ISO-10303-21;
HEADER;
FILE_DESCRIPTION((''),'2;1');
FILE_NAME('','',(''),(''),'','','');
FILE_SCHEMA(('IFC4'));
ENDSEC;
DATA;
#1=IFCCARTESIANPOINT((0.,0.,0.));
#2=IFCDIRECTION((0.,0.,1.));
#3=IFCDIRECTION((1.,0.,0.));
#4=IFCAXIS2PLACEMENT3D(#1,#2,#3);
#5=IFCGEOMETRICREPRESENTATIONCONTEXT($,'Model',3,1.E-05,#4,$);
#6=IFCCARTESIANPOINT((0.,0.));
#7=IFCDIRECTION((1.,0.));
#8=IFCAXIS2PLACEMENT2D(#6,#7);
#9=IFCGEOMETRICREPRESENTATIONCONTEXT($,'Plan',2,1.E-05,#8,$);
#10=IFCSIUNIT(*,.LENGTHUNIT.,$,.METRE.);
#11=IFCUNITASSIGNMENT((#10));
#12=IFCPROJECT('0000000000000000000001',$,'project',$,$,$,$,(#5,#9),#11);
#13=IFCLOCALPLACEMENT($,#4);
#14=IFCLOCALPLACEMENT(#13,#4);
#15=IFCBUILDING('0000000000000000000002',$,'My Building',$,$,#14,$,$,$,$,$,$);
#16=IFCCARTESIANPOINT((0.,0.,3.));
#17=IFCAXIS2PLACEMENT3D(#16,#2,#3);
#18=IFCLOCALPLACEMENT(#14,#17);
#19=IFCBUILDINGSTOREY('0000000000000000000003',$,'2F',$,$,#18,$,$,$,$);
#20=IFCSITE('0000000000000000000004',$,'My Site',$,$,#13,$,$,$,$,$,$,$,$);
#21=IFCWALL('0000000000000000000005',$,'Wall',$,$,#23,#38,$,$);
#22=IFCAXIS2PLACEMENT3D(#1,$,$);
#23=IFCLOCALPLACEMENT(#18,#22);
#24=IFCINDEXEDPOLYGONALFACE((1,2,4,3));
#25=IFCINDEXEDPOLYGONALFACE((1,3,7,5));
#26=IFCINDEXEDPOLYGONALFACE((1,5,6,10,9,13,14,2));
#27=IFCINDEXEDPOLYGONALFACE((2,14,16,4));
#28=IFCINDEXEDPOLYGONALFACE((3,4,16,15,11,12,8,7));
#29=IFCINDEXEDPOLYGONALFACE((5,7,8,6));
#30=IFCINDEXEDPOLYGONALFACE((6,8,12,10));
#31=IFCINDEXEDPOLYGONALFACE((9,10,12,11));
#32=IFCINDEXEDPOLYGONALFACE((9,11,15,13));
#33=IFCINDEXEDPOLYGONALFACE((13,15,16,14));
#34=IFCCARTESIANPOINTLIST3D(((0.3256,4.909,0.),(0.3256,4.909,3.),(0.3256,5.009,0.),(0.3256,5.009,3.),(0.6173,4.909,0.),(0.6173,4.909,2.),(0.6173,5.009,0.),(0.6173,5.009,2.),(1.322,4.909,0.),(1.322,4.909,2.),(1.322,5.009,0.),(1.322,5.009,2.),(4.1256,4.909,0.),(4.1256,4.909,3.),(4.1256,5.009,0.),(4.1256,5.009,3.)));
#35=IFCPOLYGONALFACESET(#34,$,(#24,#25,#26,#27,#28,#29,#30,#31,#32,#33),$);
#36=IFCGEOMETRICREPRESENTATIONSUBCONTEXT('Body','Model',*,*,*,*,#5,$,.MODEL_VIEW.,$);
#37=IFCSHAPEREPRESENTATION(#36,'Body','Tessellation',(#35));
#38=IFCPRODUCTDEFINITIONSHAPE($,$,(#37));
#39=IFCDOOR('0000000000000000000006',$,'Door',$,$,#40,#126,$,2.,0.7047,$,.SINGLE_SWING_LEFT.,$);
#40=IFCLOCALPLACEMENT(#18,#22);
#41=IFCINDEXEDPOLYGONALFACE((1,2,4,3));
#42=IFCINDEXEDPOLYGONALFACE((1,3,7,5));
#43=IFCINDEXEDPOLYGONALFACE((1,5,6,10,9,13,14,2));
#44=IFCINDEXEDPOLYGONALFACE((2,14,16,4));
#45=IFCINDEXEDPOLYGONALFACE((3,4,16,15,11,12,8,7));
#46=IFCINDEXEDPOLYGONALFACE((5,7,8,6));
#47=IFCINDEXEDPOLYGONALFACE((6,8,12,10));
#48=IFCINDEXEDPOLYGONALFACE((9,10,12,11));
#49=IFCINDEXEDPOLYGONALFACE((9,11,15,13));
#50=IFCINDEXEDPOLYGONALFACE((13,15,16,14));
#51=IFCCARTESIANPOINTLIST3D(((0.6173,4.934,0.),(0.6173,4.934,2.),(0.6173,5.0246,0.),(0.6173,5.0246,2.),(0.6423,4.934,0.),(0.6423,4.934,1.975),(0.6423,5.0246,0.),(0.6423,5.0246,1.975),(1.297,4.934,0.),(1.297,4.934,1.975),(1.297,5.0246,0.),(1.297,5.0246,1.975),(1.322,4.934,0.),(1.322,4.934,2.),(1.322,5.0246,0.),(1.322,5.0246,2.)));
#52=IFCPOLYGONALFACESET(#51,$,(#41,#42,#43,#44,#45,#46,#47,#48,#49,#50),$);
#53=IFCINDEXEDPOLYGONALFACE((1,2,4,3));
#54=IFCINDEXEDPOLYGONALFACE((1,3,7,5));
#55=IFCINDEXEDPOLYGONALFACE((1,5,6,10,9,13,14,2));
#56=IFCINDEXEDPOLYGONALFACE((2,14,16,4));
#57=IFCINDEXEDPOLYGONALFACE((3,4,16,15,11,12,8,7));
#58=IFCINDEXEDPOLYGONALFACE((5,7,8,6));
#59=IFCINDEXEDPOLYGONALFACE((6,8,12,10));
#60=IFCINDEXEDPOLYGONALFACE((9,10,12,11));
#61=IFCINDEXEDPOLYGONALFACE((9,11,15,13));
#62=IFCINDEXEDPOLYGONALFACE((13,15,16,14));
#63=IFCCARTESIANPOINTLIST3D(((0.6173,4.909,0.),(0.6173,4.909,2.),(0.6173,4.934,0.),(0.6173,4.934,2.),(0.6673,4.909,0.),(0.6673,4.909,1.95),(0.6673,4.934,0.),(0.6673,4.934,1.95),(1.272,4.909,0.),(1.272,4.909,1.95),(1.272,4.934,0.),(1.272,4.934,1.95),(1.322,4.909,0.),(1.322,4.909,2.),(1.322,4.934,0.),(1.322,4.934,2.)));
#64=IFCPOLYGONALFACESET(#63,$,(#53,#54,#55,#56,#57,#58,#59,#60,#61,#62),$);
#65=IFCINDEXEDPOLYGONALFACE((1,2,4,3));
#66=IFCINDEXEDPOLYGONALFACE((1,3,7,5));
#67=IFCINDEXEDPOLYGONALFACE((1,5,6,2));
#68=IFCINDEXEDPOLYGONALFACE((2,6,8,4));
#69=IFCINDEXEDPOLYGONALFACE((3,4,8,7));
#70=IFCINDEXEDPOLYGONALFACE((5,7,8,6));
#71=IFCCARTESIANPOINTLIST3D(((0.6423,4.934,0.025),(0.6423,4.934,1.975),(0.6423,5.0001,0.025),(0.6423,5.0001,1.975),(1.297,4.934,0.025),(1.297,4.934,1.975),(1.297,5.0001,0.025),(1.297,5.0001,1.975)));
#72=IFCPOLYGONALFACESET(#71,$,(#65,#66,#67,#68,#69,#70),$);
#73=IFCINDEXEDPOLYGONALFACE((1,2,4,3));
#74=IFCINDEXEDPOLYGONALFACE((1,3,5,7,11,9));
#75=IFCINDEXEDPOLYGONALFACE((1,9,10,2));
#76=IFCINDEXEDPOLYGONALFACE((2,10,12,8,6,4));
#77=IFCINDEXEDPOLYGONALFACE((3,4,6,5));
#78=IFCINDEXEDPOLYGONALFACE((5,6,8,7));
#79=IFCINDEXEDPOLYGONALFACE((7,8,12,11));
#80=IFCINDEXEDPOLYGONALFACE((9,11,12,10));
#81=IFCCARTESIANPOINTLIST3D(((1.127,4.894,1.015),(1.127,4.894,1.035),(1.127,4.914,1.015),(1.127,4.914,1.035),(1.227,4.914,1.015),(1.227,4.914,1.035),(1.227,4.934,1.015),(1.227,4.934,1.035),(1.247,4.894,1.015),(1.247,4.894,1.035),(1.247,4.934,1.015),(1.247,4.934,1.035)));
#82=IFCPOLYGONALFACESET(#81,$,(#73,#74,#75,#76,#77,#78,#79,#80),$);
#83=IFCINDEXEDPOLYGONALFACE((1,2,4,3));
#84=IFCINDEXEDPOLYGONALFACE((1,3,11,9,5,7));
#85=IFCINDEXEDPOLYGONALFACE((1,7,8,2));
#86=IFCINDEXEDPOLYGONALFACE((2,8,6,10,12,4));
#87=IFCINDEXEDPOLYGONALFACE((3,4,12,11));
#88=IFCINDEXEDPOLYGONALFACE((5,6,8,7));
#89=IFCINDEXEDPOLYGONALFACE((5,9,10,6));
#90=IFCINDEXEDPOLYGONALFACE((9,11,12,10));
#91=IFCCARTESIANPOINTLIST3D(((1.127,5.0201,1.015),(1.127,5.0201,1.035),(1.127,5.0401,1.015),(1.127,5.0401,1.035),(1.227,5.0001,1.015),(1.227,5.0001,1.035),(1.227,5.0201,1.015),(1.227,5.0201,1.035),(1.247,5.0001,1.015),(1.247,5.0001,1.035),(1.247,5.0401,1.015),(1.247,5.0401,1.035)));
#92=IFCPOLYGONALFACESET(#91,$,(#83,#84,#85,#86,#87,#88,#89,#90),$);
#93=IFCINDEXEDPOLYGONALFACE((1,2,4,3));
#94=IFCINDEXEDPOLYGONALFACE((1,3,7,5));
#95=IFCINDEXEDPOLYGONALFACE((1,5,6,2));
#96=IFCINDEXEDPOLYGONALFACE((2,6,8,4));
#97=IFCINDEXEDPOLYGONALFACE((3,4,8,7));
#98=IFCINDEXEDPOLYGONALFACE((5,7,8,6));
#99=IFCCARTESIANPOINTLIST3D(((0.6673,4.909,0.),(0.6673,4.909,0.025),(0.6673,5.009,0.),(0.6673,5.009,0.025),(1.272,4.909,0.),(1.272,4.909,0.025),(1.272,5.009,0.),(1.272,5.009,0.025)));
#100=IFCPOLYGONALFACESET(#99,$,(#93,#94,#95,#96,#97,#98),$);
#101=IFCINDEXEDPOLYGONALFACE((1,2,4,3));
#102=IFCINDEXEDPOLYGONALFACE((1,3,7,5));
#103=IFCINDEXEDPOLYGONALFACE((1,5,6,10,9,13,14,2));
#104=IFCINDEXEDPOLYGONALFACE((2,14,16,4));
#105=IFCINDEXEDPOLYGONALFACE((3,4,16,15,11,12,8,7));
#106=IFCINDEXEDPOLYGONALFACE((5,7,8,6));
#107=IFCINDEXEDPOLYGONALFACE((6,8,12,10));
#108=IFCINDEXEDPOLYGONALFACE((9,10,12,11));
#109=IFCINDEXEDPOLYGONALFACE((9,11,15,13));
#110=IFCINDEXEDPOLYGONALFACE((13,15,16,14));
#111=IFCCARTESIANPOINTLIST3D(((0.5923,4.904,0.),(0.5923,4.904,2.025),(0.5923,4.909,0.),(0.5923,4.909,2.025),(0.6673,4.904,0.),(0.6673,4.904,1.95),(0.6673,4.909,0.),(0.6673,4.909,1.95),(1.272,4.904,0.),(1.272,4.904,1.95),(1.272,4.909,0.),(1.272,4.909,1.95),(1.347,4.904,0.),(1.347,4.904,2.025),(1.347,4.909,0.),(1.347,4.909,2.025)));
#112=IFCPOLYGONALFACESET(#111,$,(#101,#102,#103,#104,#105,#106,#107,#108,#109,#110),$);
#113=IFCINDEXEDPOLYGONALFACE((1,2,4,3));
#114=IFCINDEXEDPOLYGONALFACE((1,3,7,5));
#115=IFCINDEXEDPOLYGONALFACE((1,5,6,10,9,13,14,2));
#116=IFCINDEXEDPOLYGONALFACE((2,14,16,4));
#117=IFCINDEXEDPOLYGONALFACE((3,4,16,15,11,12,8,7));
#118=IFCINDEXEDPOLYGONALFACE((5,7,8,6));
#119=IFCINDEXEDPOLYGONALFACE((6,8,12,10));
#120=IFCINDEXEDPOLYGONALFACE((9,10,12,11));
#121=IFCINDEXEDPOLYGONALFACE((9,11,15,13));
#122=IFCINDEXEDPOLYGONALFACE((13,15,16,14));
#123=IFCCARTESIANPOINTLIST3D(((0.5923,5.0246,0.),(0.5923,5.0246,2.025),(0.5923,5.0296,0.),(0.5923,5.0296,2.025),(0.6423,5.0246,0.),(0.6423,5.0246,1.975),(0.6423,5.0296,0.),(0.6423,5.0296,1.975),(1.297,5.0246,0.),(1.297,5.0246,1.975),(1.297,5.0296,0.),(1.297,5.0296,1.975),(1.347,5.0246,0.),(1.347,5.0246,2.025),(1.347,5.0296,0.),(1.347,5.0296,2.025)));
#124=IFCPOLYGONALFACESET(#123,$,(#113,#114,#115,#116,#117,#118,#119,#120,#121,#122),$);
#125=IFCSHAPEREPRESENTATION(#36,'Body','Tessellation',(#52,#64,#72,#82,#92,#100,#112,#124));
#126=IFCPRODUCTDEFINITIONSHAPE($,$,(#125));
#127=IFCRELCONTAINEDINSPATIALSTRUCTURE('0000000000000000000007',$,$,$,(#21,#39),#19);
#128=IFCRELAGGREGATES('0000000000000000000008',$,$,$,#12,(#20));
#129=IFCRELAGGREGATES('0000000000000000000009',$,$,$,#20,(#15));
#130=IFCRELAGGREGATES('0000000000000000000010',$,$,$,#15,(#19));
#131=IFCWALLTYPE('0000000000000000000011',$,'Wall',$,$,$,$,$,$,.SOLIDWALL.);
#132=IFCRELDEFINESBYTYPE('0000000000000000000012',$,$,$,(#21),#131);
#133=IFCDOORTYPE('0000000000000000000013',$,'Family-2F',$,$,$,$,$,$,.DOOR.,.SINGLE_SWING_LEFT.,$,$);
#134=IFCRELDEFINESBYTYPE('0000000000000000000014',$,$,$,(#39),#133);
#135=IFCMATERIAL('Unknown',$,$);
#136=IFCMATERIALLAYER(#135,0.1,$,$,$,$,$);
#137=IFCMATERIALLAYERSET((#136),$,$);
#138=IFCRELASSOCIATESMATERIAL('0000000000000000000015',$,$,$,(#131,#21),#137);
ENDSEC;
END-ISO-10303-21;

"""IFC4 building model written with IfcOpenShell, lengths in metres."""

from ifc_helpers import new_model, entity, si_unit, frame, origin_with_axes, origin_2d_with_axis, place, context, subcontext, project, spatial, line, indexed_curve, outline, extrude, shape, source, transform, mapped, material, layer, layer_set, layer_usage, type_object, type_shapes, element, fill, save


model = new_model("IFC4")

# Units and contexts
model_context = context("Model", 3, precision=1e-05, world=origin_with_axes())
plan_context = context("Plan", 2, precision=1e-05, world=origin_2d_with_axis())
body_context_1 = subcontext(model_context, "Body", "Model", "MODEL_VIEW")
body_context_2 = subcontext(plan_context, "Body", "Plan", "PLAN_VIEW")
ifc_project = project(units=[si_unit("LENGTHUNIT", "METRE")], contexts=[model_context, plan_context])

# Site, building, storey
site_placement = place(None, origin_with_axes())
site = spatial("IfcSite", under=ifc_project, at=site_placement, Name="My Site")
building_placement = place(site_placement, origin_with_axes())
building = spatial("IfcBuilding", under=site, at=building_placement, Name="My Building")
storey_placement = place(building_placement, frame((0.0, 0.0, 3.0), z_axis=(0.0, 0.0, 1.0), x_axis=(1.0, 0.0, 0.0)))
storey = spatial("IfcBuildingStorey", under=building, at=storey_placement, Name="2F")

# Shared definitions
ifc_material = material(Name="Unknown")

# Shared definitions
ifc_layer_1 = layer(ifc_material, 0.1)
ifc_layer_set_1 = layer_set([ifc_layer_1])
wall_type = type_object("IfcWallType", Name="Wall", PredefinedType="SOLIDWALL", material=ifc_layer_set_1)

# Wall, opening, door
ifc_layer_usage_1 = layer_usage(ifc_layer_set_1, "AXIS2", "POSITIVE", 0.0)
wall_1_placement = place(storey_placement, frame((4.1256, 5.009, 0.0), z_axis=(0.0, 0.0, 1.0), x_axis=(-1.0, 0.0, 0.0)))
wall_1 = element("IfcWall", 1, at=wall_1_placement, inside=storey, type_object=wall_type, material=ifc_layer_usage_1, Name="Wall", context=body_context_1, shape_type="SweptSolid", body=[
    extrude(outline(indexed_curve([(0.0, 0.0), (0.0, 0.1), (3.8, 0.1), (3.8, 0.0)], segments=[line(1, 2, 3, 4, 1)])), origin_with_axes(), (0.0, 0.0, 1.0), 3.0),
])
shared_shape_1 = source(origin_with_axes(), body_context_1, "Body", "SweptSolid", [
    extrude(outline(indexed_curve([(0.0, 0.0), (0.7047, 0.0), (0.7047, 2.0), (0.0, 2.0)], segments=[line(1, 2, 3, 4, 1)])), frame((0.0, -0.6, 0.0), z_axis=(0.0, -1.0, 0.0), x_axis=(1.0, 0.0, 0.0)), (0.0, 0.0, -1.0), 1.2),
])
opening_1_placement = place(wall_1_placement, frame((3.5083, 0.1, 0.0), z_axis=(0.0, 0.0, 1.0), x_axis=(-1.0, 0.0, 0.0)))
opening_1 = element("IfcOpeningElement", 2, at=opening_1_placement, cuts=wall_1, PredefinedType="OPENING", context=body_context_1, shape_type="MappedRepresentation", body=[
    mapped(shared_shape_1, transform((0.0, 0.0, 0.0), x_axis=(1.0, 0.0, 0.0), y_axis=(0.0, 1.0, 0.0), z_axis=(0.0, 0.0, 1.0), scale=1.0)),
])
door_type_1 = type_object("IfcDoorType", Name="Family-2F", OperationType="SINGLE_SWING_LEFT", PredefinedType="DOOR")
shared_shape_2 = source(origin_with_axes(), body_context_1, "Body", "SweptSolid", [
    extrude(outline(indexed_curve([(0.0, 0.0), (0.0, 2.0), (0.7047, 2.0), (0.7047, 0.0), (0.6797, 0.0), (0.6797, 1.975), (0.025, 1.975), (0.025, 0.0)], segments=[line(1, 2, 3, 4, 5, 6, 7, 8, 1)])), frame((0.0, 0.025, 0.0), z_axis=(0.0, -1.0, 0.0), x_axis=(1.0, 0.0, 0.0)), (0.0, 0.0, -1.0), 0.0906),
    extrude(outline(indexed_curve([(0.0, 0.0), (0.0, 2.0), (0.7047, 2.0), (0.7047, 0.0), (0.6547, 0.0), (0.6547, 1.95), (0.05, 1.95), (0.05, 0.0)], segments=[line(1, 2, 3, 4, 5, 6, 7, 8, 1)])), frame((0.0, 0.0, 0.0), z_axis=(0.0, -1.0, 0.0), x_axis=(1.0, 0.0, 0.0)), (0.0, 0.0, -1.0), 0.025),
    extrude(outline(indexed_curve([(0.0, 0.0), (0.6547, 0.0), (0.6547, 0.0661), (0.0, 0.0661)], segments=[line(1, 2, 3, 4, 1)])), frame((0.025, 0.025, 0.025), z_axis=(0.0, 0.0, 1.0), x_axis=(1.0, 0.0, 0.0)), (0.0, 0.0, 1.0), 1.95),
    extrude(outline(indexed_curve([(0.0, 0.0), (0.0, -0.04), (-0.12, -0.04), (-0.12, -0.02), (-0.02, -0.02), (-0.02, 0.0)], segments=[line(1, 2, 3, 4, 5, 6, 1)])), frame((0.6297, 0.025, 1.015), z_axis=(0.0, 0.0, 1.0), x_axis=(1.0, 0.0, 0.0)), (0.0, 0.0, 1.0), 0.02),
    extrude(outline(indexed_curve([(0.0, 0.0), (0.0, 0.04), (-0.12, 0.04), (-0.12, 0.02), (-0.02, 0.02), (-0.02, 0.0)], segments=[line(1, 2, 3, 4, 5, 6, 1)])), frame((0.6297, 0.0911, 1.015), z_axis=(0.0, 0.0, 1.0), x_axis=(1.0, 0.0, 0.0)), (0.0, 0.0, 1.0), 0.02),
    extrude(outline(indexed_curve([(0.0, 0.0), (0.6047, 0.0), (0.6047, 0.1), (0.0, 0.1)], segments=[line(1, 2, 3, 4, 1)])), frame((0.05, 0.0, 0.0), z_axis=(0.0, 0.0, 1.0), x_axis=(1.0, 0.0, 0.0)), (0.0, 0.0, 1.0), 0.025),
    extrude(outline(indexed_curve([(0.0, 0.0), (0.0, 2.025), (0.7547, 2.025), (0.7547, 0.0), (0.6797, 0.0), (0.6797, 1.95), (0.075, 1.95), (0.075, 0.0)], segments=[line(1, 2, 3, 4, 5, 6, 7, 8, 1)])), frame((-0.025, -0.005, 0.0), z_axis=(0.0, -1.0, 0.0), x_axis=(1.0, 0.0, 0.0)), (0.0, 0.0, -1.0), 0.005),
    extrude(outline(indexed_curve([(0.0, 0.0), (0.0, 2.025), (0.7547, 2.025), (0.7547, 0.0), (0.7047, 0.0), (0.7047, 1.975), (0.05, 1.975), (0.05, 0.0)], segments=[line(1, 2, 3, 4, 5, 6, 7, 8, 1)])), frame((-0.025, 0.1156, 0.0), z_axis=(0.0, -1.0, 0.0), x_axis=(1.0, 0.0, 0.0)), (0.0, 0.0, -1.0), 0.005),
])
shared_shape_3 = source(origin_with_axes(), body_context_2, "Body", "Curve2D", [
    entity("IfcIndexedPolyCurve", entity("IfcCartesianPointList2D", [[0.0, 0.0], [0.0, 0.1156], [0.025, 0.1156], [0.025, 0.025], [0.05, 0.025], [0.05, 0.0]]), [entity("IfcLineIndex", [1, 2, 3, 4, 5, 6, 1])]),
    entity("IfcIndexedPolyCurve", entity("IfcCartesianPointList2D", [[0.7047, 0.0], [0.7047, 0.1156], [0.6797, 0.1156], [0.6797, 0.025], [0.6547, 0.025], [0.6547, 0.0]]), [entity("IfcLineIndex", [1, 2, 3, 4, 5, 6, 1])]),
    entity("IfcTrimmedCurve", entity("IfcEllipse", entity("IfcAxis2Placement2D", entity("IfcCartesianPoint", [0.0911, 0.1156]), entity("IfcDirection", [1.0, 0.0])), 0.5886, 0.6547), [entity("IfcCartesianPoint", [0.6797, 0.1156])], [entity("IfcCartesianPoint", [0.0911, 0.7702])], True, "CARTESIAN"),
    entity("IfcIndexedPolyCurve", entity("IfcCartesianPointList2D", [[0.025, 0.1156], [0.0911, 0.1156], [0.0911, 0.7702], [0.025, 0.7702]]), [entity("IfcLineIndex", [1, 2, 3, 4, 1])]),
])
type_shapes(door_type_1, [shared_shape_2, shared_shape_3])
door_1_placement = place(opening_1_placement, frame((0.0, 0.0, 0.0), z_axis=(0.0, 0.0, 1.0), x_axis=(1.0, 0.0, 0.0)))
door_1 = element("IfcDoor", 3, at=door_1_placement, inside=storey, type_object=door_type_1, Name="Door", OperationType="SINGLE_SWING_LEFT", OverallHeight=2.0, OverallWidth=0.7047, shapes=[
    shape(body_context_1, "Body", "MappedRepresentation", [mapped(shared_shape_2, transform((0.0, 0.0, 0.0), x_axis=(1.0, 0.0, 0.0), y_axis=(0.0, 1.0, 0.0), z_axis=(0.0, 0.0, 1.0), scale=1.0))]),
    shape(body_context_2, "Body", "MappedRepresentation", [mapped(shared_shape_3, transform((0.0, 0.0, 0.0), x_axis=(1.0, 0.0, 0.0), y_axis=(0.0, 1.0, 0.0), z_axis=(0.0, 0.0, 1.0), scale=1.0))]),
])
fill(opening_1, door_1)

save(model, "model.ifc")
